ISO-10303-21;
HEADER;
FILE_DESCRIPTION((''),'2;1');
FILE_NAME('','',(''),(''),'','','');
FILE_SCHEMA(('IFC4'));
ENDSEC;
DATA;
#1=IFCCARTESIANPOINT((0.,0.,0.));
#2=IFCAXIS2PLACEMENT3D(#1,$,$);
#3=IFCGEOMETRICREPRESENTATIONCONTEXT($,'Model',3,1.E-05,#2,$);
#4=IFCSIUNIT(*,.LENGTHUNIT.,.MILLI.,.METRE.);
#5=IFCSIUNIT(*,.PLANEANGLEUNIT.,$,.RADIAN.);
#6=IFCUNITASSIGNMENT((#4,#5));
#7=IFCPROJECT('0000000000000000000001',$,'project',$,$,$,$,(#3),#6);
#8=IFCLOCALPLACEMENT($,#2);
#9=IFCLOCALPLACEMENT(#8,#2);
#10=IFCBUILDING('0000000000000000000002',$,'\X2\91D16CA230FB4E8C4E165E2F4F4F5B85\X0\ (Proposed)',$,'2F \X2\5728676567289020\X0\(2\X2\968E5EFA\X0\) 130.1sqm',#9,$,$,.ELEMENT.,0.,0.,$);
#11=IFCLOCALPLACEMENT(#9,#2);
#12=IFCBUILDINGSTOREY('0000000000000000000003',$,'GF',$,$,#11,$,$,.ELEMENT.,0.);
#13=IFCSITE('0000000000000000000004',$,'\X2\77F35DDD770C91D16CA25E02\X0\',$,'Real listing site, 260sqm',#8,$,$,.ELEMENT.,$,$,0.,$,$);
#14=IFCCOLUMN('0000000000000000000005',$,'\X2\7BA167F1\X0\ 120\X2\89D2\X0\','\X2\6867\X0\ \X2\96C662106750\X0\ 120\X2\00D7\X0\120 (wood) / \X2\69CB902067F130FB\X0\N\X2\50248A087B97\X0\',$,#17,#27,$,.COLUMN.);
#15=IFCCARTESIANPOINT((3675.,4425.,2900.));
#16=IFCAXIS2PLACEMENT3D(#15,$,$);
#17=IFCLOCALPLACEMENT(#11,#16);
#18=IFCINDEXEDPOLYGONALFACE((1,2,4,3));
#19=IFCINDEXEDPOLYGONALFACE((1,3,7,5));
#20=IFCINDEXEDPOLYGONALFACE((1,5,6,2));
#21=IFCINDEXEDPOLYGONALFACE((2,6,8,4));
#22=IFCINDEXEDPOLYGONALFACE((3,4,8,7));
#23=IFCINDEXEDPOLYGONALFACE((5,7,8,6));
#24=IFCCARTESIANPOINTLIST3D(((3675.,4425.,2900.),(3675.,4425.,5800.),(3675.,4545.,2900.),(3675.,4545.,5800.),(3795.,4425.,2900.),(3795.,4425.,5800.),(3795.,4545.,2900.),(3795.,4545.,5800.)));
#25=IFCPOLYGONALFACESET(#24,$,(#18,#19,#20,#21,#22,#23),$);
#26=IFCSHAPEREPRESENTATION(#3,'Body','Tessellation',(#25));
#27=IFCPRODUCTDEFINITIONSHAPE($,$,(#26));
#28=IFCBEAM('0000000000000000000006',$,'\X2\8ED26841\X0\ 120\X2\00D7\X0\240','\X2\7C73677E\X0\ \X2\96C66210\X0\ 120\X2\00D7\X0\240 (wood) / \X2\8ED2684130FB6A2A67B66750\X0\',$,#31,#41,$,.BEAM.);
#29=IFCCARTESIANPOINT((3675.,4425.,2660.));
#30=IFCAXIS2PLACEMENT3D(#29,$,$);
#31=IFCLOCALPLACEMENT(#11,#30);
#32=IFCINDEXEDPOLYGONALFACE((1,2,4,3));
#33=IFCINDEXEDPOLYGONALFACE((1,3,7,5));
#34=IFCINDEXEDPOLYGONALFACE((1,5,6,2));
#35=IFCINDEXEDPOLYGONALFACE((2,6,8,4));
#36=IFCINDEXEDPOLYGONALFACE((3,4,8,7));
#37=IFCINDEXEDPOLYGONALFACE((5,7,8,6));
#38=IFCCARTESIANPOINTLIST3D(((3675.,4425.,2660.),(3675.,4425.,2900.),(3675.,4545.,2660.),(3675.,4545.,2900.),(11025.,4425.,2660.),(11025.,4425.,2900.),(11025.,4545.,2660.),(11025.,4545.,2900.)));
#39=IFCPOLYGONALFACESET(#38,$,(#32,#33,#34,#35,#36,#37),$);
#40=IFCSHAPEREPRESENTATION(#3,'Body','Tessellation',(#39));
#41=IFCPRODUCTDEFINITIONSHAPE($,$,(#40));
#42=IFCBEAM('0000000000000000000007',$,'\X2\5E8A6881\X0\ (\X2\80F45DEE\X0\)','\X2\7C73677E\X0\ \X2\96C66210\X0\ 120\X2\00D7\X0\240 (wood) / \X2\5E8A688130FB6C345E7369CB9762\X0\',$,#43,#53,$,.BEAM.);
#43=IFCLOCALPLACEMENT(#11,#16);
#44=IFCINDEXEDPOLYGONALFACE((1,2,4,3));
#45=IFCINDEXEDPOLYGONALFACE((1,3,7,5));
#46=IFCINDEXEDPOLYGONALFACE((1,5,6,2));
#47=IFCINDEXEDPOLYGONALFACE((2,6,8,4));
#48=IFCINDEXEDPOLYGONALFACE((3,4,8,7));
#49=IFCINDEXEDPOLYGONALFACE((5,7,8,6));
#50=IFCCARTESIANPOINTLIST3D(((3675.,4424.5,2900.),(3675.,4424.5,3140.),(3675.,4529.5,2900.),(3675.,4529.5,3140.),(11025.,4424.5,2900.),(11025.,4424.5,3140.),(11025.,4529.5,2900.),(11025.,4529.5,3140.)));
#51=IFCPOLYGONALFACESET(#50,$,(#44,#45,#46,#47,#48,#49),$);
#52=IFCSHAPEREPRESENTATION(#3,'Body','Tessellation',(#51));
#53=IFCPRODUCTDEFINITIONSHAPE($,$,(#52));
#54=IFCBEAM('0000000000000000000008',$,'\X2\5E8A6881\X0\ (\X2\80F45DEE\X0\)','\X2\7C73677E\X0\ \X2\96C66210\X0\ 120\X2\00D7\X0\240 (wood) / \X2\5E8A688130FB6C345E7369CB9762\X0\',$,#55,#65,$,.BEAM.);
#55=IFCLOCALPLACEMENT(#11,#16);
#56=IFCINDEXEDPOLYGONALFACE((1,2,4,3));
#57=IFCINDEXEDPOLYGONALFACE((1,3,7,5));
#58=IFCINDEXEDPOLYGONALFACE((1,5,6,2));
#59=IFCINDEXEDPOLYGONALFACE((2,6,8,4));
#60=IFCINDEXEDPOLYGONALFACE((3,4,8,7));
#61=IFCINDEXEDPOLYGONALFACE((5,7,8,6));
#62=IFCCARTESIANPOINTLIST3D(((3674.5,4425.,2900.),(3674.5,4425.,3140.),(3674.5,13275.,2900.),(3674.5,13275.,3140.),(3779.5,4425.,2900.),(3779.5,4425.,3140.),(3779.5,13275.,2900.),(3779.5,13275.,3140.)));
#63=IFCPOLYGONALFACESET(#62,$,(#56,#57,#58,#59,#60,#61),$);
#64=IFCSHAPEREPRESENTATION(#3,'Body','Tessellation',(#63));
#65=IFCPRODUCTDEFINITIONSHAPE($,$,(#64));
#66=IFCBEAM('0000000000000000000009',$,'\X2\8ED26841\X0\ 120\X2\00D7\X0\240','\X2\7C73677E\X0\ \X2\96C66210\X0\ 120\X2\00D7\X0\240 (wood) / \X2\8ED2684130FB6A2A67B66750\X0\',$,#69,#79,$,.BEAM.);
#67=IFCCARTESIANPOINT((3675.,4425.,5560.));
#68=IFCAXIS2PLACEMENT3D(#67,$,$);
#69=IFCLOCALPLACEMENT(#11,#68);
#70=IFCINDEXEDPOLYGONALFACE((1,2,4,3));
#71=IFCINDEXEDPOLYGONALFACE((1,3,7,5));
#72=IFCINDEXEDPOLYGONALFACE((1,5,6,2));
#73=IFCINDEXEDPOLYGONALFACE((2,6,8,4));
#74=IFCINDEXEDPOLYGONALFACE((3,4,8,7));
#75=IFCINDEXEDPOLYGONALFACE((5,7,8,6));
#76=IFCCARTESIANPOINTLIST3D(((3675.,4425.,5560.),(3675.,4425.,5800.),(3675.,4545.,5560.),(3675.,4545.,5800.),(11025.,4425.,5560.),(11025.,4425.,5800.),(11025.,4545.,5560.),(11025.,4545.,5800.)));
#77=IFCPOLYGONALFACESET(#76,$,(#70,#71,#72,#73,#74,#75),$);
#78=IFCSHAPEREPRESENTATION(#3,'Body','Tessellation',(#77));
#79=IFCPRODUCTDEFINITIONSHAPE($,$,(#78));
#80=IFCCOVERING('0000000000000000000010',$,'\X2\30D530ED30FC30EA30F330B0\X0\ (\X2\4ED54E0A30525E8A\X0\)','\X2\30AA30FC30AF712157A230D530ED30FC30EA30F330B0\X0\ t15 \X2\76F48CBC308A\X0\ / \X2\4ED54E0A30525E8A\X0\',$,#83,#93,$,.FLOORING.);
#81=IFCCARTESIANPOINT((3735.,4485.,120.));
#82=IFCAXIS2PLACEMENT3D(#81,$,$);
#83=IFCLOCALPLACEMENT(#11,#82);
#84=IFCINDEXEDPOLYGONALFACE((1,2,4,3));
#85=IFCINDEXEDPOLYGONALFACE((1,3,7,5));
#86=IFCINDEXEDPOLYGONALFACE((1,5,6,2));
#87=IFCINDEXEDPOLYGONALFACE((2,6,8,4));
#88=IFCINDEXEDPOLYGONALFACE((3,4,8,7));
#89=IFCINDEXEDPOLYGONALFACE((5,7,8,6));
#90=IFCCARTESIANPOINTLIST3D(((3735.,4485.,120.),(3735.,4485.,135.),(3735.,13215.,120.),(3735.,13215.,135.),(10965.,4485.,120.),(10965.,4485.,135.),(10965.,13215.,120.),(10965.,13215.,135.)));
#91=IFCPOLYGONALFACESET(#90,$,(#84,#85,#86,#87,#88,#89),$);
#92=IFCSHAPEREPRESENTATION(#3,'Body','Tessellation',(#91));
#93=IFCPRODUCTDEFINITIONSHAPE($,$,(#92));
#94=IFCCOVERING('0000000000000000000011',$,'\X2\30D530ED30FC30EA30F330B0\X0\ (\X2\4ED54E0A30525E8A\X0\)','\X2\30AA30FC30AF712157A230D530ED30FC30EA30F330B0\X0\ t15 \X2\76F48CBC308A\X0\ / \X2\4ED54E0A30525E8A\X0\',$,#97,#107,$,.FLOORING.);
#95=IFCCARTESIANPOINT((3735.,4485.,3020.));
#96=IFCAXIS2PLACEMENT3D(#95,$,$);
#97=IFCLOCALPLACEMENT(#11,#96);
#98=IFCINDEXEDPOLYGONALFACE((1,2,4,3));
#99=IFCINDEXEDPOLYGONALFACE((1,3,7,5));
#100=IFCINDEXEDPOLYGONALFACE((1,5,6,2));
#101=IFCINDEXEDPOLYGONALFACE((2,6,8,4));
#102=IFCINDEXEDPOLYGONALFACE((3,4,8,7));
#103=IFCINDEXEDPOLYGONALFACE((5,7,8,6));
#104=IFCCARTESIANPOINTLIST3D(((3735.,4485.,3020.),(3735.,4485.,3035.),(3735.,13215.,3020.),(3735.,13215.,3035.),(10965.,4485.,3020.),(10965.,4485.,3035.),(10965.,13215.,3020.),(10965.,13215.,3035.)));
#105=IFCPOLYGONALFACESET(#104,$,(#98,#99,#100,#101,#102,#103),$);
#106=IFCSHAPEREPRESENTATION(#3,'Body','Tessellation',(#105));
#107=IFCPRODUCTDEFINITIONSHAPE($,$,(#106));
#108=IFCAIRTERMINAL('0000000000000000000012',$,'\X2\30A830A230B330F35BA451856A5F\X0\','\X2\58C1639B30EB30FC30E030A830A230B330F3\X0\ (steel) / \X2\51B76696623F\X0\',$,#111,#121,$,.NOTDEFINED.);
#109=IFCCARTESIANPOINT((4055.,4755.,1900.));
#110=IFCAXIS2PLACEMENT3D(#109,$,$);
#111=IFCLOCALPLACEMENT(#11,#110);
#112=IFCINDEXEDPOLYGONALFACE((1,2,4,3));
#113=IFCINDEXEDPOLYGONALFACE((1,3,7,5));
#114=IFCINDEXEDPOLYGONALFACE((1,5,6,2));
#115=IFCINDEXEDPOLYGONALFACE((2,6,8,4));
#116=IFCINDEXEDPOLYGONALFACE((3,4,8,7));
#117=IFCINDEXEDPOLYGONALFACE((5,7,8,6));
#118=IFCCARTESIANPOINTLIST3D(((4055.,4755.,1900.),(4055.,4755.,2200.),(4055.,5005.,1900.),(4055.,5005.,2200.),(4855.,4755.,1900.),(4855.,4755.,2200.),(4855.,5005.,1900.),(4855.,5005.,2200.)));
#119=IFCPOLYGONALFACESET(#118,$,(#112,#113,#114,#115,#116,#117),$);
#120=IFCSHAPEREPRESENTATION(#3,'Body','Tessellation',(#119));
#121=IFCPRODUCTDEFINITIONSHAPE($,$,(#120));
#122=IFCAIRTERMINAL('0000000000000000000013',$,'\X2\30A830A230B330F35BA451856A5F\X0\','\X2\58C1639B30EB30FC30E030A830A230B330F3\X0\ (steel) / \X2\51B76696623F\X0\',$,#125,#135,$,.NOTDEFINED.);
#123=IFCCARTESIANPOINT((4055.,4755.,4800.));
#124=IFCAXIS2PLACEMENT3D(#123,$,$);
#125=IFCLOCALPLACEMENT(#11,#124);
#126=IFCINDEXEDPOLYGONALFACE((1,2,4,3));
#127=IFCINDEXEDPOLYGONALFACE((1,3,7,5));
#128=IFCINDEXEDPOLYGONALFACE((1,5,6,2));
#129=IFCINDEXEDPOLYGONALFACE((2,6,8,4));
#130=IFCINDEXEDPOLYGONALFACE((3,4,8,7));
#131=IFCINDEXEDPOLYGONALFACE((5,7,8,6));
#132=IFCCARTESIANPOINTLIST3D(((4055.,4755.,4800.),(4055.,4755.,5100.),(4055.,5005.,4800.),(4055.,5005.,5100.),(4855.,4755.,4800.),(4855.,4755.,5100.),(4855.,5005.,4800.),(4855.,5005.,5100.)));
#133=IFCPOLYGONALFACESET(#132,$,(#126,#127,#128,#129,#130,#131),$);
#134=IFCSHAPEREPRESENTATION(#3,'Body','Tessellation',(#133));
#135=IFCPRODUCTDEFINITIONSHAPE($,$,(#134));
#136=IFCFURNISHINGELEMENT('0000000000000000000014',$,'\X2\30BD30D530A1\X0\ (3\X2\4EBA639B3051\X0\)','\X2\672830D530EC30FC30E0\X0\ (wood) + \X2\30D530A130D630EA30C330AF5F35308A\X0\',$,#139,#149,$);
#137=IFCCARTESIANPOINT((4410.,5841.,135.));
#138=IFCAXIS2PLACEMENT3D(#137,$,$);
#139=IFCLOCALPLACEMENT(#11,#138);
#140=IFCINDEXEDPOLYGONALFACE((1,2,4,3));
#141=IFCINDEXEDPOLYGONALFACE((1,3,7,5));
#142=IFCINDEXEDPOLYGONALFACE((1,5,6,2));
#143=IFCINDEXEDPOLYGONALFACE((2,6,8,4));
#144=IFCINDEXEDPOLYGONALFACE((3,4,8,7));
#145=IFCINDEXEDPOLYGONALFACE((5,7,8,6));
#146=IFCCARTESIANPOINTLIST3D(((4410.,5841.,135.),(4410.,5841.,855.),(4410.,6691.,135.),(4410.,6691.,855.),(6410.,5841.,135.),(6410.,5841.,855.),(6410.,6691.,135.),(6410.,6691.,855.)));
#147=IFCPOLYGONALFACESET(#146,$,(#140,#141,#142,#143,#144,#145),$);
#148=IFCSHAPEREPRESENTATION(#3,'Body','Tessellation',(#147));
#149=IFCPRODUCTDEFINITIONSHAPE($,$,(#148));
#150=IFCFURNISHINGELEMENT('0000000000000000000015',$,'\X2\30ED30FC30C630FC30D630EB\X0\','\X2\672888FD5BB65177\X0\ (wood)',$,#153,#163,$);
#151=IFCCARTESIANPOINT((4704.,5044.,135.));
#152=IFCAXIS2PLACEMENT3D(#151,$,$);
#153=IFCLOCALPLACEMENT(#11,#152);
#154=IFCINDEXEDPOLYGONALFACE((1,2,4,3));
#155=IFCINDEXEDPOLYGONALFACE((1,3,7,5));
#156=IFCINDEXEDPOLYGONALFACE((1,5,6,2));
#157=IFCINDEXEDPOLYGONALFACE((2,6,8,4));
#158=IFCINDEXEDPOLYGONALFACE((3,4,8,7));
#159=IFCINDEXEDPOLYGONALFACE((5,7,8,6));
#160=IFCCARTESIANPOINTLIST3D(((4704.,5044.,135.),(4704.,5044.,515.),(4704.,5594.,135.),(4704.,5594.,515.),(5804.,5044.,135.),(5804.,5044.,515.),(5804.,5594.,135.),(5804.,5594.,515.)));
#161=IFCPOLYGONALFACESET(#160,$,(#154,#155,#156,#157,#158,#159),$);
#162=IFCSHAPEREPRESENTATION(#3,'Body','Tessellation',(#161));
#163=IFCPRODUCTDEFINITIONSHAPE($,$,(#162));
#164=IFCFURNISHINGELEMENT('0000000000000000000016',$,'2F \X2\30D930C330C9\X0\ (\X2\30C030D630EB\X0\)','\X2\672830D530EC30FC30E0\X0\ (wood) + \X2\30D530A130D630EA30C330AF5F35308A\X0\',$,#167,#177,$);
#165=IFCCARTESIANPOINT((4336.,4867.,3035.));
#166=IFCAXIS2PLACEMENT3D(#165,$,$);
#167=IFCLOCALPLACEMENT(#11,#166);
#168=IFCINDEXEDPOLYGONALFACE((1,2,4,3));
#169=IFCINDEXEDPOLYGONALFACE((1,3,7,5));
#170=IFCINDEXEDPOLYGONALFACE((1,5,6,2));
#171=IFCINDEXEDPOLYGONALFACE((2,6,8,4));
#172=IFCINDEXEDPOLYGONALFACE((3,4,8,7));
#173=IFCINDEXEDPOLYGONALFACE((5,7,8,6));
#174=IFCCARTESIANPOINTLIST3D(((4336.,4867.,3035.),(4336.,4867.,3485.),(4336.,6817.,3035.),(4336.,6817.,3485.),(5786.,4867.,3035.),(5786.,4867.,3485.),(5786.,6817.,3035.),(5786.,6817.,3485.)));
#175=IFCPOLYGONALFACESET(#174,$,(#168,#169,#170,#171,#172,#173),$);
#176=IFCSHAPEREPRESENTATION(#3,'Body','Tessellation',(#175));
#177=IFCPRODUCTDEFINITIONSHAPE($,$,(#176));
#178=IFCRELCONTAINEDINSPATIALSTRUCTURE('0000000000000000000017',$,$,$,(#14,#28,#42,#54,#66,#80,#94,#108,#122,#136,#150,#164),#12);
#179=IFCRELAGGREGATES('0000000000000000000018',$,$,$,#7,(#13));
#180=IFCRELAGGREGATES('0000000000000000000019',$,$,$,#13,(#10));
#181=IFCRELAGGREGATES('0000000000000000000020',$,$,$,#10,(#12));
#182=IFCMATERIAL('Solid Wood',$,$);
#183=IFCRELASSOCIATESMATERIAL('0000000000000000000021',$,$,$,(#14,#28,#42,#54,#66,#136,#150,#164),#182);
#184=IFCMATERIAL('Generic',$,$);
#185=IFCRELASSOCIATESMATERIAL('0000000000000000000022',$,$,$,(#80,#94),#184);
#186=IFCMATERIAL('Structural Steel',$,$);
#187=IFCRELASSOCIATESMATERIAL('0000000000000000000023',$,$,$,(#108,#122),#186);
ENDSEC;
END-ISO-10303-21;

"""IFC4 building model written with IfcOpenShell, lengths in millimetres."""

from ifc_helpers import new_model, si_unit, frame, frame_2d, origin, place, context, project, spatial, rectangle, extrude, material, element, save


model = new_model("IFC4")

# Units and contexts
model_context = context("Model", 3, precision=1e-05, world=origin())
ifc_project = project(units=[si_unit("LENGTHUNIT", "METRE", prefix="MILLI"), si_unit("PLANEANGLEUNIT", "RADIAN")], contexts=[model_context])

# Site, building, storey
site_placement = place(None, origin())
site = spatial("IfcSite", under=ifc_project, at=site_placement, Name="石川県金沢市", ObjectType="Real listing site, 260sqm", CompositionType="ELEMENT", RefElevation=0.0)
building_placement = place(site_placement, origin())
building = spatial("IfcBuilding", under=site, at=building_placement, Name="金沢・二世帯住宅 (Proposed)", ObjectType="2F 在来木造(2階建) 130.1sqm", CompositionType="ELEMENT", ElevationOfRefHeight=0.0, ElevationOfTerrain=0.0)
storey_placement = place(building_placement, origin())
storey = spatial("IfcBuildingStorey", under=building, at=storey_placement, Name="GF", CompositionType="ELEMENT", Elevation=0.0)

# Column
ifc_material_1 = material(Name="Solid Wood")
column_1_placement = place(storey_placement, frame((3675.0, 4425.0, 2900.0)))
element("IfcColumn", 1, at=column_1_placement, inside=storey, material=ifc_material_1, Name="管柱 120角", Description="桧 集成材 120×120 (wood) / 構造柱・N値計算", PredefinedType="COLUMN", context=model_context, shape_type="SweptSolid", body=[
    extrude(rectangle(XDim=120.0, YDim=120.0, at=frame_2d((60.0, 60.0))), frame((3675.0, 4425.0, 2900.0)), (0.0, 0.0, 1.0), 2900.0),
])

# Beams
beam_1_placement = place(storey_placement, frame((3675.0, 4425.0, 2660.0)))
element("IfcBeam", 2, at=beam_1_placement, inside=storey, material=ifc_material_1, Name="軒桁 120×240", Description="米松 集成 120×240 (wood) / 軒桁・横架材", PredefinedType="BEAM", context=model_context, shape_type="SweptSolid", body=[
    extrude(rectangle(XDim=7350.0, YDim=120.0, at=frame_2d((3675.0, 60.0))), frame((3675.0, 4425.0, 2660.0)), (0.0, 0.0, 1.0), 240.0),
])
beam_2_placement = place(storey_placement, frame((3675.0, 4425.0, 2900.0)))
element("IfcBeam", 3, at=beam_2_placement, inside=storey, material=ifc_material_1, Name="床梁 (胴差)", Description="米松 集成 120×240 (wood) / 床梁・水平構面", PredefinedType="BEAM", context=model_context, shape_type="SweptSolid", body=[
    extrude(rectangle(XDim=7350.0, YDim=105.0, at=frame_2d((3675.0, 52.0))), frame((3675.0, 4425.0, 2900.0)), (0.0, 0.0, 1.0), 240.0),
])
beam_3_placement = place(storey_placement, frame((3675.0, 4425.0, 2900.0)))
element("IfcBeam", 4, at=beam_3_placement, inside=storey, material=ifc_material_1, Name="床梁 (胴差)", Description="米松 集成 120×240 (wood) / 床梁・水平構面", PredefinedType="BEAM", context=model_context, shape_type="SweptSolid", body=[
    extrude(rectangle(XDim=105.0, YDim=8850.0, at=frame_2d((52.0, 4425.0))), frame((3675.0, 4425.0, 2900.0)), (0.0, 0.0, 1.0), 240.0),
])
beam_4_placement = place(storey_placement, frame((3675.0, 4425.0, 5560.0)))
element("IfcBeam", 5, at=beam_4_placement, inside=storey, material=ifc_material_1, Name="軒桁 120×240", Description="米松 集成 120×240 (wood) / 軒桁・横架材", PredefinedType="BEAM", context=model_context, shape_type="SweptSolid", body=[
    extrude(rectangle(XDim=7350.0, YDim=120.0, at=frame_2d((3675.0, 60.0))), frame((3675.0, 4425.0, 5560.0)), (0.0, 0.0, 1.0), 240.0),
])

# Coverings
ifc_material_2 = material(Name="Generic")
covering_1_placement = place(storey_placement, frame((3735.0, 4485.0, 120.0)))
element("IfcCovering", 6, at=covering_1_placement, inside=storey, material=ifc_material_2, Name="フローリング (仕上げ床)", Description="オーク無垢フローリング t15 直貼り / 仕上げ床", PredefinedType="FLOORING", context=model_context, shape_type="SweptSolid", body=[
    extrude(rectangle(XDim=7230.0, YDim=8730.0, at=frame_2d((3615.0, 4365.0))), frame((3735.0, 4485.0, 120.0)), (0.0, 0.0, 1.0), 15.0),
])
covering_2_placement = place(storey_placement, frame((3735.0, 4485.0, 3020.0)))
element("IfcCovering", 7, at=covering_2_placement, inside=storey, material=ifc_material_2, Name="フローリング (仕上げ床)", Description="オーク無垢フローリング t15 直貼り / 仕上げ床", PredefinedType="FLOORING", context=model_context, shape_type="SweptSolid", body=[
    extrude(rectangle(XDim=7230.0, YDim=8730.0, at=frame_2d((3615.0, 4365.0))), frame((3735.0, 4485.0, 3020.0)), (0.0, 0.0, 1.0), 15.0),
])

# Air terminals
ifc_material_3 = material(Name="Structural Steel")
air_terminal_1_placement = place(storey_placement, frame((4055.0, 4755.0, 1900.0)))
element("IfcAirTerminal", 8, at=air_terminal_1_placement, inside=storey, material=ifc_material_3, Name="エアコン室内機", Description="壁掛ルームエアコン (steel) / 冷暖房", PredefinedType="NOTDEFINED", context=model_context, shape_type="SweptSolid", body=[
    extrude(rectangle(XDim=800.0, YDim=250.0, at=frame_2d((400.0, 125.0))), frame((4055.0, 4755.0, 1900.0)), (0.0, 0.0, 1.0), 300.0),
])
air_terminal_2_placement = place(storey_placement, frame((4055.0, 4755.0, 4800.0)))
element("IfcAirTerminal", 9, at=air_terminal_2_placement, inside=storey, material=ifc_material_3, Name="エアコン室内機", Description="壁掛ルームエアコン (steel) / 冷暖房", PredefinedType="NOTDEFINED", context=model_context, shape_type="SweptSolid", body=[
    extrude(rectangle(XDim=800.0, YDim=250.0, at=frame_2d((400.0, 125.0))), frame((4055.0, 4755.0, 4800.0)), (0.0, 0.0, 1.0), 300.0),
])

# Furnishing elements
furnishing_1_placement = place(storey_placement, frame((4410.0, 5841.0, 135.0)))
element("IfcFurnishingElement", 10, at=furnishing_1_placement, inside=storey, material=ifc_material_1, Name="ソファ (3人掛け)", Description="木フレーム (wood) + ファブリック張り", context=model_context, shape_type="SweptSolid", body=[
    extrude(rectangle(XDim=2000.0, YDim=850.0, at=frame_2d((1000.0, 425.0))), frame((4410.0, 5841.0, 135.0)), (0.0, 0.0, 1.0), 720.0),
])
furnishing_2_placement = place(storey_placement, frame((4704.0, 5044.0, 135.0)))
element("IfcFurnishingElement", 11, at=furnishing_2_placement, inside=storey, material=ifc_material_1, Name="ローテーブル", Description="木製家具 (wood)", context=model_context, shape_type="SweptSolid", body=[
    extrude(rectangle(XDim=1100.0, YDim=550.0, at=frame_2d((550.0, 275.0))), frame((4704.0, 5044.0, 135.0)), (0.0, 0.0, 1.0), 380.0),
])
furnishing_3_placement = place(storey_placement, frame((4336.0, 4867.0, 3035.0)))
element("IfcFurnishingElement", 12, at=furnishing_3_placement, inside=storey, material=ifc_material_1, Name="2F ベッド (ダブル)", Description="木フレーム (wood) + ファブリック張り", context=model_context, shape_type="SweptSolid", body=[
    extrude(rectangle(XDim=1450.0, YDim=1950.0, at=frame_2d((725.0, 975.0))), frame((4336.0, 4867.0, 3035.0)), (0.0, 0.0, 1.0), 450.0),
])

save(model, "model.ifc")
